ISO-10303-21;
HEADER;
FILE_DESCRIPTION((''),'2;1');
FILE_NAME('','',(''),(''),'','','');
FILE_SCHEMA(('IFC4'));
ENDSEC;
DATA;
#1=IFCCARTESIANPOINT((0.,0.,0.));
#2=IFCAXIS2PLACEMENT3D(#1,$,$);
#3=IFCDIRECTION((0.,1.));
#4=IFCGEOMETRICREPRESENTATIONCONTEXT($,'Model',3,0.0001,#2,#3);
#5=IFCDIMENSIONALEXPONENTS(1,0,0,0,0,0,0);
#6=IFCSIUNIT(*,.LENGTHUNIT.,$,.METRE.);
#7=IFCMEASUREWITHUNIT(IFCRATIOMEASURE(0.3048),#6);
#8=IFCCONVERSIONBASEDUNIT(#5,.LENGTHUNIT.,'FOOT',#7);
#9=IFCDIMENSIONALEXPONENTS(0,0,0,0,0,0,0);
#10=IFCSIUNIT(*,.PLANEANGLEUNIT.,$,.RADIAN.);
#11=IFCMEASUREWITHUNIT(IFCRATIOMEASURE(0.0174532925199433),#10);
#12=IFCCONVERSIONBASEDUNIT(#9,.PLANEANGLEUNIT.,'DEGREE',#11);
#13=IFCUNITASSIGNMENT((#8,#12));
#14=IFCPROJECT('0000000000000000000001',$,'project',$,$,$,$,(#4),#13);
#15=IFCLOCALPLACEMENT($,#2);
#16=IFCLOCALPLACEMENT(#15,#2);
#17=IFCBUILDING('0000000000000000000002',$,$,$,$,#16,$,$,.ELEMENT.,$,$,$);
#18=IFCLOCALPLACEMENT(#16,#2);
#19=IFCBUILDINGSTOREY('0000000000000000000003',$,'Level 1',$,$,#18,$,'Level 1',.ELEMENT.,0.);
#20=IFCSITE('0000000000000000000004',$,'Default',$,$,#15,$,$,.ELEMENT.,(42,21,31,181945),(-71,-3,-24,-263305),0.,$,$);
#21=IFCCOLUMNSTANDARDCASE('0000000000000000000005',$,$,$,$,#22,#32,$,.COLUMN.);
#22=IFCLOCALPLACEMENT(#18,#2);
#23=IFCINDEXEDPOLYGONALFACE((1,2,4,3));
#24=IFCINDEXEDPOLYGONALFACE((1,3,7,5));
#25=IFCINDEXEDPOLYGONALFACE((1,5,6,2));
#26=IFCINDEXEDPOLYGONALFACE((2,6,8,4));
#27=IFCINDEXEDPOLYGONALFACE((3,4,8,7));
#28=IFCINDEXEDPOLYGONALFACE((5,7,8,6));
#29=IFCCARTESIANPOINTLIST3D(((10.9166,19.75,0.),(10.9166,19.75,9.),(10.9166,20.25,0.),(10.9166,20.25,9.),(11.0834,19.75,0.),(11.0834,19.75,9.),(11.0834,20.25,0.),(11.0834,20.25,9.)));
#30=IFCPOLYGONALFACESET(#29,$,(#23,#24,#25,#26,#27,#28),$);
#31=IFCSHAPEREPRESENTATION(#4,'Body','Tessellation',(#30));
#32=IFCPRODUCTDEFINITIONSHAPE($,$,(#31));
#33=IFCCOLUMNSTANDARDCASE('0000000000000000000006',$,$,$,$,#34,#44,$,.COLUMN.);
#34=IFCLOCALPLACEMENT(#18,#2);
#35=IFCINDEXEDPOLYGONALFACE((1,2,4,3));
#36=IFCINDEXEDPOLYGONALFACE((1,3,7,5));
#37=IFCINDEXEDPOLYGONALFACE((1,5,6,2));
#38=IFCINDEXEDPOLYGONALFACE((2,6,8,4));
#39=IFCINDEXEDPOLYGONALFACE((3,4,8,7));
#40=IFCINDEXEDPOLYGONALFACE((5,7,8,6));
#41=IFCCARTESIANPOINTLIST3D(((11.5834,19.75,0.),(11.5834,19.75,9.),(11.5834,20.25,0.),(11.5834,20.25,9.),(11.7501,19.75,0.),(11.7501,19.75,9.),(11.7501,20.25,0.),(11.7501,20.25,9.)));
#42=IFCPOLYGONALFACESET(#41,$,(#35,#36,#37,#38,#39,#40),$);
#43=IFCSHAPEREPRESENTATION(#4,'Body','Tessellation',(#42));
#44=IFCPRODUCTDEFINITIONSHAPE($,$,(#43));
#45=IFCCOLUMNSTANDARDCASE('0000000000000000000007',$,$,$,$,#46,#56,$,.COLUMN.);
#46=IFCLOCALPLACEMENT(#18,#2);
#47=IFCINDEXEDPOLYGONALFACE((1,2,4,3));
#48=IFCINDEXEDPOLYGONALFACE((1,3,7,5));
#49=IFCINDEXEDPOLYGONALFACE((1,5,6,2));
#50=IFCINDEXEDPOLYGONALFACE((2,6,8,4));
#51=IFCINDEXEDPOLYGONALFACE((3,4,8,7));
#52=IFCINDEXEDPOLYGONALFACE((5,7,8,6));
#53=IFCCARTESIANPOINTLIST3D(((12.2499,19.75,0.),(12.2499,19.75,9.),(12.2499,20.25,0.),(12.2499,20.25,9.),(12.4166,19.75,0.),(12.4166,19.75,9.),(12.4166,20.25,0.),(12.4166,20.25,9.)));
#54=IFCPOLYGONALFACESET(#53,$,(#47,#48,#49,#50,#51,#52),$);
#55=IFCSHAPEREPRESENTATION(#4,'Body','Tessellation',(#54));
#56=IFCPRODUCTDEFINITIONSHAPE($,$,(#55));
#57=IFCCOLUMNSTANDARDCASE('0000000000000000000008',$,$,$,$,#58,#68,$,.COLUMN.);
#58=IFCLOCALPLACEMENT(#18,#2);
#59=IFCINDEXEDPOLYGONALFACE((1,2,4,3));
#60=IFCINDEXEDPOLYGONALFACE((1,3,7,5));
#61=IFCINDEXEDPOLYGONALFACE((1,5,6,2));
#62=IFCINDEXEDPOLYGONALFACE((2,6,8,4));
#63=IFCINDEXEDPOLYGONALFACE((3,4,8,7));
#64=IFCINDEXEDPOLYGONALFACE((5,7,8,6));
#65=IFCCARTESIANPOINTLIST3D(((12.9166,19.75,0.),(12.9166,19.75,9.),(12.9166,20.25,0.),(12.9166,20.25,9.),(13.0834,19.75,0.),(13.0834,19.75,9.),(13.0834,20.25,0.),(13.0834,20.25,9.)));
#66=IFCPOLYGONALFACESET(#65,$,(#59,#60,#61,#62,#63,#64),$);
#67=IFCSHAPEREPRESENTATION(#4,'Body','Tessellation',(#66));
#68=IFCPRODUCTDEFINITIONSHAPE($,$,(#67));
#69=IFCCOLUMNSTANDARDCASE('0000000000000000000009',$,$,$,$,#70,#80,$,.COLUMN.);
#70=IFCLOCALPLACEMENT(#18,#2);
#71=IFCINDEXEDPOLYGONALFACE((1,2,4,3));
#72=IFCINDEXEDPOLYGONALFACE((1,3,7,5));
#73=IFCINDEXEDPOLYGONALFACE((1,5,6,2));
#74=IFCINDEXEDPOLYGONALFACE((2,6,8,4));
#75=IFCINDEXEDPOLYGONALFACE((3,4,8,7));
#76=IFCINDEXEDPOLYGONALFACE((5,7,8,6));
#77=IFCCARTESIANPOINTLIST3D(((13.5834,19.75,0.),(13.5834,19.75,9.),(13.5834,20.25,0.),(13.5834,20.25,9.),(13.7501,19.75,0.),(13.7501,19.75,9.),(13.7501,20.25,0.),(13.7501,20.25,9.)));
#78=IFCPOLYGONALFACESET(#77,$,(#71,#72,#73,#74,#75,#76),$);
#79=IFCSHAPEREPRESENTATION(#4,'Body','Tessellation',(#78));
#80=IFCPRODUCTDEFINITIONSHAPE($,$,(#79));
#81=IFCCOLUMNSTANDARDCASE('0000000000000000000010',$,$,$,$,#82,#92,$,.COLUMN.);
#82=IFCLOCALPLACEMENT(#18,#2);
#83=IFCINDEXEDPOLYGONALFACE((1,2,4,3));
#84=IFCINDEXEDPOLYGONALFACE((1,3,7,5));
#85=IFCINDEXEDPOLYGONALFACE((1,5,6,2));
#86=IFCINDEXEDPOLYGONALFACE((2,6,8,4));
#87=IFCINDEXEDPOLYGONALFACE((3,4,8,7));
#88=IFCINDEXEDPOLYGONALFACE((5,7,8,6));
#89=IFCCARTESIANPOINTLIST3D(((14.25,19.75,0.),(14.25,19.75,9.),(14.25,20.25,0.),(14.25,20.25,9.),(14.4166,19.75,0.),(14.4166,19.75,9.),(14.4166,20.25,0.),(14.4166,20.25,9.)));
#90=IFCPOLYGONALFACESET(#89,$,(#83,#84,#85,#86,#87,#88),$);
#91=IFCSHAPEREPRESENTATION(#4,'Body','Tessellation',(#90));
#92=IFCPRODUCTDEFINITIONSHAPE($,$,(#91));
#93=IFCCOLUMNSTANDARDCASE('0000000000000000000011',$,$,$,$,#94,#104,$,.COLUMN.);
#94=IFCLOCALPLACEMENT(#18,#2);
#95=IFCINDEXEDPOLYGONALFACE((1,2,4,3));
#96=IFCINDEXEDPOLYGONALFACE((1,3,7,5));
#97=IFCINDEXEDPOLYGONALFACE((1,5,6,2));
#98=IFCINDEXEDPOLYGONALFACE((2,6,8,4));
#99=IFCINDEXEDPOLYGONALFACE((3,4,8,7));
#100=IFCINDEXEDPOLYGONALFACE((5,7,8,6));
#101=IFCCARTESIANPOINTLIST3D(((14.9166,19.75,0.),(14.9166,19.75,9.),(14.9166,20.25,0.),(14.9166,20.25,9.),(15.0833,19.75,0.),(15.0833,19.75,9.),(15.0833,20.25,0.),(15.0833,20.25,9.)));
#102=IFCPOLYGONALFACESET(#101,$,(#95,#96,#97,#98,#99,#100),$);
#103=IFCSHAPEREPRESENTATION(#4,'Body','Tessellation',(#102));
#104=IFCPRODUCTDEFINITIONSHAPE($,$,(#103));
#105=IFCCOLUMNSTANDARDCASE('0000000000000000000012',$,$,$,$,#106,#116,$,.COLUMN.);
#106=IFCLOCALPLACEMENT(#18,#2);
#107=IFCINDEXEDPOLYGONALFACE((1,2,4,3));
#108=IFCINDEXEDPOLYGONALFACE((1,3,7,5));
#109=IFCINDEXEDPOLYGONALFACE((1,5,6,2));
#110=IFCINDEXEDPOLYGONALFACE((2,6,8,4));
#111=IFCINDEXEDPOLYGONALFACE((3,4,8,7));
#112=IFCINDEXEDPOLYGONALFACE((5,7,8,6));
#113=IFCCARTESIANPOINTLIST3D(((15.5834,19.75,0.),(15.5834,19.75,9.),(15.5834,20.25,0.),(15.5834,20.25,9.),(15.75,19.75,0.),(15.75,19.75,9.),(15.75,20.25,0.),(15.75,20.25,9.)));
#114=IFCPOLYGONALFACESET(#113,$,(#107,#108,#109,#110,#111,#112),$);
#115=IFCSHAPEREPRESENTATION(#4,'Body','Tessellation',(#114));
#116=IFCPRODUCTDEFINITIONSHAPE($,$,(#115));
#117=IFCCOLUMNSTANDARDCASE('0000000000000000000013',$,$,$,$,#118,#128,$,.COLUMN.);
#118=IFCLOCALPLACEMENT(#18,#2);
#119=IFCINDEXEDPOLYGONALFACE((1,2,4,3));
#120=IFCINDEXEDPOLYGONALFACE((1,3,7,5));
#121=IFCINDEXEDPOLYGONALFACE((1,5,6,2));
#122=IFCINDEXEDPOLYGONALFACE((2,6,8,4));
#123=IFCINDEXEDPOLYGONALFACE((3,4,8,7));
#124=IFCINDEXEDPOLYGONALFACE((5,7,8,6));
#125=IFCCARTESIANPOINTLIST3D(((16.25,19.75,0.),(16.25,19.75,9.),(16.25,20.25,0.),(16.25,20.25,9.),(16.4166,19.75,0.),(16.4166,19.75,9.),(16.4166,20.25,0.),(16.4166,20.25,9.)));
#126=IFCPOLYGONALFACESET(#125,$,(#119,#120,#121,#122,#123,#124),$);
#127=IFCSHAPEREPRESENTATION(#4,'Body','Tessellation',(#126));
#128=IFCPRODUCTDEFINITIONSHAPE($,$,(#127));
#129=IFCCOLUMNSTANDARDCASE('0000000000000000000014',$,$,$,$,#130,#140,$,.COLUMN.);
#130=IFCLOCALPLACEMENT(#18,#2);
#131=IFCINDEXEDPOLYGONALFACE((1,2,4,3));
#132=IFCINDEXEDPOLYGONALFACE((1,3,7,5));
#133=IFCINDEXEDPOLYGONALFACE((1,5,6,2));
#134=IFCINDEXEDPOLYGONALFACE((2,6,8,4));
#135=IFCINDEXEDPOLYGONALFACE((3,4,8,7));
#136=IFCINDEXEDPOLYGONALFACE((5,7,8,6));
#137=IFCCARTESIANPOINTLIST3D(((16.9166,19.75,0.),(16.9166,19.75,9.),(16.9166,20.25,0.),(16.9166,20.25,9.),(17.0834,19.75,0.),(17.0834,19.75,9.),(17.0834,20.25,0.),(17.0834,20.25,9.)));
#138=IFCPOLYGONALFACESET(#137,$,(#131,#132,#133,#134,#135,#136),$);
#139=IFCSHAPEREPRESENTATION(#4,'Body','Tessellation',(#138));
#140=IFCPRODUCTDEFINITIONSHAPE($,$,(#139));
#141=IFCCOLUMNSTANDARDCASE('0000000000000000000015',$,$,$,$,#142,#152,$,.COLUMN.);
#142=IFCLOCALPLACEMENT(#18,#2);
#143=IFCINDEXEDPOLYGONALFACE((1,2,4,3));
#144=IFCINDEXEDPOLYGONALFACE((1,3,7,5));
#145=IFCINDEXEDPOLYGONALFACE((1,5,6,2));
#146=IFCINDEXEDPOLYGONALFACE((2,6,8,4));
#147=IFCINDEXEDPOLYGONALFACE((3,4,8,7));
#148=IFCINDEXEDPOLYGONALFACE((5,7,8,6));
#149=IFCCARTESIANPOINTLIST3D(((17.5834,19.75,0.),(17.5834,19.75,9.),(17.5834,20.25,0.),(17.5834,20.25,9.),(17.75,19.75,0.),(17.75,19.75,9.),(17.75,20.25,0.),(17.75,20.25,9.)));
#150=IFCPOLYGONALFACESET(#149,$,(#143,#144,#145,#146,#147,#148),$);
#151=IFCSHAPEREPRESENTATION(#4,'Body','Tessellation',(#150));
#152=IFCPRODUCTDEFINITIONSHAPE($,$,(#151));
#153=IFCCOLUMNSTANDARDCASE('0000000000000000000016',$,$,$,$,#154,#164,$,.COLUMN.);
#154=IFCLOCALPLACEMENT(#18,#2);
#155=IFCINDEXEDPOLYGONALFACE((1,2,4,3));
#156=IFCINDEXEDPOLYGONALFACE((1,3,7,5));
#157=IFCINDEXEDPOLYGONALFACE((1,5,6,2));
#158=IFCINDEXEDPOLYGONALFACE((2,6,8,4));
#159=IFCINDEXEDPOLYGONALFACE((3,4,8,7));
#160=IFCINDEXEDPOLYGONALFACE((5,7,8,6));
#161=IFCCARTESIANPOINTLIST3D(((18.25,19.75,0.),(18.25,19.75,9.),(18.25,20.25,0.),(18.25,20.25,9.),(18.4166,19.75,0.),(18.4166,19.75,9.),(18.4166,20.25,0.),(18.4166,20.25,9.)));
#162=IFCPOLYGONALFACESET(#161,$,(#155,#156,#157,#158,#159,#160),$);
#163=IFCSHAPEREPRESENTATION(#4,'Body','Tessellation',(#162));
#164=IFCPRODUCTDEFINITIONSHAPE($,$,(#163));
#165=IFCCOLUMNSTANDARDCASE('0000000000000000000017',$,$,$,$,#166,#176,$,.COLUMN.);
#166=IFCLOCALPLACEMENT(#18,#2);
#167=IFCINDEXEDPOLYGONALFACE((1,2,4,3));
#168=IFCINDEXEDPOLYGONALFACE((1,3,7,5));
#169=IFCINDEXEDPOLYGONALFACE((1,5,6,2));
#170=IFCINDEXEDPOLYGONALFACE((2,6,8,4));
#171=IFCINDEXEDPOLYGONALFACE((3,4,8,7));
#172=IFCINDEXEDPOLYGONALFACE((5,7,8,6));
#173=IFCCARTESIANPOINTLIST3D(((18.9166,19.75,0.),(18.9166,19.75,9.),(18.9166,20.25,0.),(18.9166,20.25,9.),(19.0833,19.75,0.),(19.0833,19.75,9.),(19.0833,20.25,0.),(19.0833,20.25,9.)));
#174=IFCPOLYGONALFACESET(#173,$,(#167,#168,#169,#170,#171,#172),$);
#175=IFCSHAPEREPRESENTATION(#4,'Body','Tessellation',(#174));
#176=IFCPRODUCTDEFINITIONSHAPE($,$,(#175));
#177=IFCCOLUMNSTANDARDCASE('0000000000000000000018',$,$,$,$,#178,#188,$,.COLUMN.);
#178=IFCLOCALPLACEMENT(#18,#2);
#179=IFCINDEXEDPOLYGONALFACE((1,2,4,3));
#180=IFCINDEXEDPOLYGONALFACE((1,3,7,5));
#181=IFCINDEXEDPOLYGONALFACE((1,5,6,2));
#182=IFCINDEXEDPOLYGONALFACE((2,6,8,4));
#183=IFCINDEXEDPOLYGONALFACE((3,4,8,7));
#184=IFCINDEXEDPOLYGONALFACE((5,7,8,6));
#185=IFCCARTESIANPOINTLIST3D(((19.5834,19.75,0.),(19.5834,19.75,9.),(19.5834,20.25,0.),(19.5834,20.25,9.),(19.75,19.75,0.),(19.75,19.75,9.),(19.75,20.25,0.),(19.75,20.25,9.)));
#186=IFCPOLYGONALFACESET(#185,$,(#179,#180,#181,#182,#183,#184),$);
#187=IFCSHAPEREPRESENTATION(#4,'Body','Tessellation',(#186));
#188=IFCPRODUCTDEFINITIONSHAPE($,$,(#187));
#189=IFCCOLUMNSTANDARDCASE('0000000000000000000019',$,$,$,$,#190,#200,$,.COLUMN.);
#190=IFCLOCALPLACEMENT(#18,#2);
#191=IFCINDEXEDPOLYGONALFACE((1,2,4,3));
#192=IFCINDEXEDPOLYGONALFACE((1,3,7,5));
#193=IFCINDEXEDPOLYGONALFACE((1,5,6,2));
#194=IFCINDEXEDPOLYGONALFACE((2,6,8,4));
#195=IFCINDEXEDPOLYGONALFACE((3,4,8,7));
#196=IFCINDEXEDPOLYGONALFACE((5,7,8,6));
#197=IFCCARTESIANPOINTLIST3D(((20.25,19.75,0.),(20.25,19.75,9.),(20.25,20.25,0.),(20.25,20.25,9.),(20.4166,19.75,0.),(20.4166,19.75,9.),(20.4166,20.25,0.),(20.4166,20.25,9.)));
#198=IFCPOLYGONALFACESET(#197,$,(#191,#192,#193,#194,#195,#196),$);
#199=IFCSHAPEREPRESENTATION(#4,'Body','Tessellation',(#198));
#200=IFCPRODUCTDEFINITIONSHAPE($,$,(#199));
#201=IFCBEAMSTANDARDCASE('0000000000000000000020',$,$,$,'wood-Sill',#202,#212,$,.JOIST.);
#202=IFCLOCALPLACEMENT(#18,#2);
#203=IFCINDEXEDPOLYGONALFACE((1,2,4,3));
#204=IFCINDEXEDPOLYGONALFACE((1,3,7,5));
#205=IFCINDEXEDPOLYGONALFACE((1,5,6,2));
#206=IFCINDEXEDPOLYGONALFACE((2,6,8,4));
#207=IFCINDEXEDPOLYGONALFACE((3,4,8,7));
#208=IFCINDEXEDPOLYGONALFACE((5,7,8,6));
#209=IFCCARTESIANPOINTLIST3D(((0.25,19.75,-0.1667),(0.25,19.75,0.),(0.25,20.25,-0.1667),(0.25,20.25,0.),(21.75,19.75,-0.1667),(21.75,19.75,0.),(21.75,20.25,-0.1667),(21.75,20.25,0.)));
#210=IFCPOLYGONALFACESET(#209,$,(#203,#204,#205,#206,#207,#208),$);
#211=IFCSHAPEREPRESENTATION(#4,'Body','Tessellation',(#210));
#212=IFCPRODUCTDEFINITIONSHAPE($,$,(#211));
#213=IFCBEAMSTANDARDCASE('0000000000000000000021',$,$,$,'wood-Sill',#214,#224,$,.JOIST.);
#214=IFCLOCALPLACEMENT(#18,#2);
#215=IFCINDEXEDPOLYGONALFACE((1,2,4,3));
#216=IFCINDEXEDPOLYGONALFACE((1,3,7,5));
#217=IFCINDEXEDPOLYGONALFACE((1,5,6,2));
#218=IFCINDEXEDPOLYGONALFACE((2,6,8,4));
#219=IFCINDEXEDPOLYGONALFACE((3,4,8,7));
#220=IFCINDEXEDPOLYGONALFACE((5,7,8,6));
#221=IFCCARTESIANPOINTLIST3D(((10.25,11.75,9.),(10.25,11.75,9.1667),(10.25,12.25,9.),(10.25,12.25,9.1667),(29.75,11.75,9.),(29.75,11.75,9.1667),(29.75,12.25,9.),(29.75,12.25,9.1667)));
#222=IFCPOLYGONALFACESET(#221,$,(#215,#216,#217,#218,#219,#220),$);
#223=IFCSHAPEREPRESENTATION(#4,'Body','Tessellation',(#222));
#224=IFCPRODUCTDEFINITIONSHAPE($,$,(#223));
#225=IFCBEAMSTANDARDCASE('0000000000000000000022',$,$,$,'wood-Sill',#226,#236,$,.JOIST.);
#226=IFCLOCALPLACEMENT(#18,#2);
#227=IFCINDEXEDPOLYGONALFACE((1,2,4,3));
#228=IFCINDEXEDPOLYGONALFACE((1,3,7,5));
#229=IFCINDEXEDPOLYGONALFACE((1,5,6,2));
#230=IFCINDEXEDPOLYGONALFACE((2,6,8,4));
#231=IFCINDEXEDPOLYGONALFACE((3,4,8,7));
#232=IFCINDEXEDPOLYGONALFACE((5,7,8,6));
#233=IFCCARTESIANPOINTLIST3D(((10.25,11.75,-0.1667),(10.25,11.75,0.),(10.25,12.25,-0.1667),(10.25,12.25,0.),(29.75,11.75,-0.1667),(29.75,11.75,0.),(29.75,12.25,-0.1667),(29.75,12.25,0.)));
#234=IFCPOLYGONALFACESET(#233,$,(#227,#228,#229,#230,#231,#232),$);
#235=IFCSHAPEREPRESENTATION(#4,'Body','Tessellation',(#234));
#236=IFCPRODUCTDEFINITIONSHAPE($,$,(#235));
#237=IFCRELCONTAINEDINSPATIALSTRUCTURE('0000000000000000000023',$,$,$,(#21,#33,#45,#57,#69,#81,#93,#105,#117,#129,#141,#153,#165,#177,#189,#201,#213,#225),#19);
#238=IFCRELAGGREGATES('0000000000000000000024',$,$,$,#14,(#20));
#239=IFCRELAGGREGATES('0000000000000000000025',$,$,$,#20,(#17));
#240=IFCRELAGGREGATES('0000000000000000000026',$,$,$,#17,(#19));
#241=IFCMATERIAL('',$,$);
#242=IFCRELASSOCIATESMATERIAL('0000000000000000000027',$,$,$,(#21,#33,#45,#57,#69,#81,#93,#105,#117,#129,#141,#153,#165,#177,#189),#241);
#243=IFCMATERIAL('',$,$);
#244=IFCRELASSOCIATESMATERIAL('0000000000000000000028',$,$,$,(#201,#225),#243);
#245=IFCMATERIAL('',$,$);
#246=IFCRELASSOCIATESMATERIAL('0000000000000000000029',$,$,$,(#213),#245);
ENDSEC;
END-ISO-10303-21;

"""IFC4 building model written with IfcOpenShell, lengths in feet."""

from ifc_helpers import new_model, entity, si_unit, converted_unit, direction, frame, origin, place, context, project, spatial, rectangle, extrude, material, element, save


model = new_model("IFC4")

# Units and contexts
model_context = context("Model", 3, precision=0.0001, world=origin(), true_north=direction((0.0, 1.0)))
ifc_project = project(units=[converted_unit("LENGTHUNIT", "FOOT", entity("IfcRatioMeasure", 0.3048), si_unit("LENGTHUNIT", "METRE"), dimensions=[1, 0, 0, 0, 0, 0, 0]), converted_unit("PLANEANGLEUNIT", "DEGREE", entity("IfcRatioMeasure", 0.0174532925199433), si_unit("PLANEANGLEUNIT", "RADIAN"), dimensions=[0, 0, 0, 0, 0, 0, 0])], contexts=[model_context])

# Site, building, storey
site_placement = place(None, origin())
site = spatial("IfcSite", under=ifc_project, at=site_placement, Name="Default", CompositionType="ELEMENT", RefLatitude=(42, 21, 31, 181945), RefLongitude=(-71, -3, -24, -263305), RefElevation=0.0)
building_placement = place(site_placement, origin())
building = spatial("IfcBuilding", under=site, at=building_placement, CompositionType="ELEMENT")
storey_placement = place(building_placement, origin())
storey = spatial("IfcBuildingStorey", under=building, at=storey_placement, Name="Level 1", LongName="Level 1", CompositionType="ELEMENT", Elevation=0.0)

# Columns
ifc_material_1 = material(Name="")
placement_1 = place(storey_placement, frame((0.25, 20.0, 0.0)))
for number, where, z_axis, x_axis in (
    (1, (10.75, 0.0, 0.0), (0.0, 0.0, 1.0), (1.0, 0.0, 0.0)),
    (2, (11.4167, 0.0, 0.0), (0.0, 0.0, 1.0), (1.0, 0.0, 0.0)),
    (3, (12.0833, 0.0, 0.0), (0.0, 0.0, 1.0), (1.0, 0.0, 0.0)),
    (4, (12.75, 0.0, 0.0), (0.0, 0.0, 1.0), (1.0, 0.0, 0.0)),
    (5, (13.4167, 0.0, 0.0), (0.0, 0.0, 1.0), (1.0, 0.0, 0.0)),
    (6, (14.0833, 0.0, 0.0), (0.0, 0.0, 1.0), (1.0, 0.0, 0.0)),
    (7, (14.75, 0.0, 0.0), (0.0, 0.0, 1.0), (1.0, 0.0, 0.0)),
    (8, (15.4167, 0.0, 0.0), (0.0, 0.0, 1.0), (1.0, 0.0, 0.0)),
    (9, (16.0833, 0.0, 0.0), (0.0, 0.0, 1.0), (1.0, 0.0, 0.0)),
    (10, (16.75, 0.0, 0.0), (0.0, 0.0, 1.0), (1.0, 0.0, 0.0)),
    (11, (17.4167, 0.0, 0.0), (0.0, 0.0, 1.0), (1.0, 0.0, 0.0)),
    (12, (18.0833, 0.0, 0.0), (0.0, 0.0, 1.0), (1.0, 0.0, 0.0)),
    (13, (18.75, 0.0, 0.0), (0.0, 0.0, 1.0), (1.0, 0.0, 0.0)),
    (14, (19.4167, 0.0, 0.0), (0.0, 0.0, 1.0), (1.0, 0.0, 0.0)),
    (15, (20.0833, 0.0, 0.0), (0.0, 0.0, 1.0), (1.0, 0.0, 0.0)),
):
    element("IfcColumnStandardCase", number, at=place(placement_1, frame(where, z_axis=z_axis, x_axis=x_axis)), inside=storey, material=ifc_material_1, PredefinedType="COLUMN", context=model_context, shape_type="SweptSolid", body=[
        extrude(rectangle(XDim=0.1667, YDim=0.5), origin(), (0.0, 0.0, 1.0), 9.0),
    ])
placement_2 = place(storey_placement, frame((10.25, 12.0, 0.0)))

# Beams
ifc_material_2 = material(Name="")
beam_1_placement = place(placement_1, frame((10.75, 0.0, -0.1667), z_axis=(0.0, 0.0, 1.0), x_axis=(1.0, 0.0, 0.0)))
element("IfcBeamStandardCase", 16, at=beam_1_placement, inside=storey, material=ifc_material_2, ObjectType="wood-Sill", PredefinedType="JOIST", context=model_context, shape_type="SweptSolid", body=[
    extrude(rectangle(XDim=21.5, YDim=0.5), origin(), (0.0, 0.0, 1.0), 0.1667),
])
ifc_material_3 = material(Name="")
beam_2_placement = place(placement_2, frame((9.75, 0.0, 9.0), z_axis=(0.0, 0.0, 1.0), x_axis=(1.0, 0.0, 0.0)))
element("IfcBeamStandardCase", 17, at=beam_2_placement, inside=storey, material=ifc_material_3, ObjectType="wood-Sill", PredefinedType="JOIST", context=model_context, shape_type="SweptSolid", body=[
    extrude(rectangle(XDim=19.5, YDim=0.5), origin(), (0.0, 0.0, 1.0), 0.1667),
])
beam_3_placement = place(placement_2, frame((9.75, 0.0, -0.1667), z_axis=(0.0, 0.0, 1.0), x_axis=(1.0, 0.0, 0.0)))
element("IfcBeamStandardCase", 18, at=beam_3_placement, inside=storey, material=ifc_material_2, ObjectType="wood-Sill", PredefinedType="JOIST", context=model_context, shape_type="SweptSolid", body=[
    extrude(rectangle(XDim=19.5, YDim=0.5), origin(), (0.0, 0.0, 1.0), 0.1667),
])

save(model, "model.ifc")
